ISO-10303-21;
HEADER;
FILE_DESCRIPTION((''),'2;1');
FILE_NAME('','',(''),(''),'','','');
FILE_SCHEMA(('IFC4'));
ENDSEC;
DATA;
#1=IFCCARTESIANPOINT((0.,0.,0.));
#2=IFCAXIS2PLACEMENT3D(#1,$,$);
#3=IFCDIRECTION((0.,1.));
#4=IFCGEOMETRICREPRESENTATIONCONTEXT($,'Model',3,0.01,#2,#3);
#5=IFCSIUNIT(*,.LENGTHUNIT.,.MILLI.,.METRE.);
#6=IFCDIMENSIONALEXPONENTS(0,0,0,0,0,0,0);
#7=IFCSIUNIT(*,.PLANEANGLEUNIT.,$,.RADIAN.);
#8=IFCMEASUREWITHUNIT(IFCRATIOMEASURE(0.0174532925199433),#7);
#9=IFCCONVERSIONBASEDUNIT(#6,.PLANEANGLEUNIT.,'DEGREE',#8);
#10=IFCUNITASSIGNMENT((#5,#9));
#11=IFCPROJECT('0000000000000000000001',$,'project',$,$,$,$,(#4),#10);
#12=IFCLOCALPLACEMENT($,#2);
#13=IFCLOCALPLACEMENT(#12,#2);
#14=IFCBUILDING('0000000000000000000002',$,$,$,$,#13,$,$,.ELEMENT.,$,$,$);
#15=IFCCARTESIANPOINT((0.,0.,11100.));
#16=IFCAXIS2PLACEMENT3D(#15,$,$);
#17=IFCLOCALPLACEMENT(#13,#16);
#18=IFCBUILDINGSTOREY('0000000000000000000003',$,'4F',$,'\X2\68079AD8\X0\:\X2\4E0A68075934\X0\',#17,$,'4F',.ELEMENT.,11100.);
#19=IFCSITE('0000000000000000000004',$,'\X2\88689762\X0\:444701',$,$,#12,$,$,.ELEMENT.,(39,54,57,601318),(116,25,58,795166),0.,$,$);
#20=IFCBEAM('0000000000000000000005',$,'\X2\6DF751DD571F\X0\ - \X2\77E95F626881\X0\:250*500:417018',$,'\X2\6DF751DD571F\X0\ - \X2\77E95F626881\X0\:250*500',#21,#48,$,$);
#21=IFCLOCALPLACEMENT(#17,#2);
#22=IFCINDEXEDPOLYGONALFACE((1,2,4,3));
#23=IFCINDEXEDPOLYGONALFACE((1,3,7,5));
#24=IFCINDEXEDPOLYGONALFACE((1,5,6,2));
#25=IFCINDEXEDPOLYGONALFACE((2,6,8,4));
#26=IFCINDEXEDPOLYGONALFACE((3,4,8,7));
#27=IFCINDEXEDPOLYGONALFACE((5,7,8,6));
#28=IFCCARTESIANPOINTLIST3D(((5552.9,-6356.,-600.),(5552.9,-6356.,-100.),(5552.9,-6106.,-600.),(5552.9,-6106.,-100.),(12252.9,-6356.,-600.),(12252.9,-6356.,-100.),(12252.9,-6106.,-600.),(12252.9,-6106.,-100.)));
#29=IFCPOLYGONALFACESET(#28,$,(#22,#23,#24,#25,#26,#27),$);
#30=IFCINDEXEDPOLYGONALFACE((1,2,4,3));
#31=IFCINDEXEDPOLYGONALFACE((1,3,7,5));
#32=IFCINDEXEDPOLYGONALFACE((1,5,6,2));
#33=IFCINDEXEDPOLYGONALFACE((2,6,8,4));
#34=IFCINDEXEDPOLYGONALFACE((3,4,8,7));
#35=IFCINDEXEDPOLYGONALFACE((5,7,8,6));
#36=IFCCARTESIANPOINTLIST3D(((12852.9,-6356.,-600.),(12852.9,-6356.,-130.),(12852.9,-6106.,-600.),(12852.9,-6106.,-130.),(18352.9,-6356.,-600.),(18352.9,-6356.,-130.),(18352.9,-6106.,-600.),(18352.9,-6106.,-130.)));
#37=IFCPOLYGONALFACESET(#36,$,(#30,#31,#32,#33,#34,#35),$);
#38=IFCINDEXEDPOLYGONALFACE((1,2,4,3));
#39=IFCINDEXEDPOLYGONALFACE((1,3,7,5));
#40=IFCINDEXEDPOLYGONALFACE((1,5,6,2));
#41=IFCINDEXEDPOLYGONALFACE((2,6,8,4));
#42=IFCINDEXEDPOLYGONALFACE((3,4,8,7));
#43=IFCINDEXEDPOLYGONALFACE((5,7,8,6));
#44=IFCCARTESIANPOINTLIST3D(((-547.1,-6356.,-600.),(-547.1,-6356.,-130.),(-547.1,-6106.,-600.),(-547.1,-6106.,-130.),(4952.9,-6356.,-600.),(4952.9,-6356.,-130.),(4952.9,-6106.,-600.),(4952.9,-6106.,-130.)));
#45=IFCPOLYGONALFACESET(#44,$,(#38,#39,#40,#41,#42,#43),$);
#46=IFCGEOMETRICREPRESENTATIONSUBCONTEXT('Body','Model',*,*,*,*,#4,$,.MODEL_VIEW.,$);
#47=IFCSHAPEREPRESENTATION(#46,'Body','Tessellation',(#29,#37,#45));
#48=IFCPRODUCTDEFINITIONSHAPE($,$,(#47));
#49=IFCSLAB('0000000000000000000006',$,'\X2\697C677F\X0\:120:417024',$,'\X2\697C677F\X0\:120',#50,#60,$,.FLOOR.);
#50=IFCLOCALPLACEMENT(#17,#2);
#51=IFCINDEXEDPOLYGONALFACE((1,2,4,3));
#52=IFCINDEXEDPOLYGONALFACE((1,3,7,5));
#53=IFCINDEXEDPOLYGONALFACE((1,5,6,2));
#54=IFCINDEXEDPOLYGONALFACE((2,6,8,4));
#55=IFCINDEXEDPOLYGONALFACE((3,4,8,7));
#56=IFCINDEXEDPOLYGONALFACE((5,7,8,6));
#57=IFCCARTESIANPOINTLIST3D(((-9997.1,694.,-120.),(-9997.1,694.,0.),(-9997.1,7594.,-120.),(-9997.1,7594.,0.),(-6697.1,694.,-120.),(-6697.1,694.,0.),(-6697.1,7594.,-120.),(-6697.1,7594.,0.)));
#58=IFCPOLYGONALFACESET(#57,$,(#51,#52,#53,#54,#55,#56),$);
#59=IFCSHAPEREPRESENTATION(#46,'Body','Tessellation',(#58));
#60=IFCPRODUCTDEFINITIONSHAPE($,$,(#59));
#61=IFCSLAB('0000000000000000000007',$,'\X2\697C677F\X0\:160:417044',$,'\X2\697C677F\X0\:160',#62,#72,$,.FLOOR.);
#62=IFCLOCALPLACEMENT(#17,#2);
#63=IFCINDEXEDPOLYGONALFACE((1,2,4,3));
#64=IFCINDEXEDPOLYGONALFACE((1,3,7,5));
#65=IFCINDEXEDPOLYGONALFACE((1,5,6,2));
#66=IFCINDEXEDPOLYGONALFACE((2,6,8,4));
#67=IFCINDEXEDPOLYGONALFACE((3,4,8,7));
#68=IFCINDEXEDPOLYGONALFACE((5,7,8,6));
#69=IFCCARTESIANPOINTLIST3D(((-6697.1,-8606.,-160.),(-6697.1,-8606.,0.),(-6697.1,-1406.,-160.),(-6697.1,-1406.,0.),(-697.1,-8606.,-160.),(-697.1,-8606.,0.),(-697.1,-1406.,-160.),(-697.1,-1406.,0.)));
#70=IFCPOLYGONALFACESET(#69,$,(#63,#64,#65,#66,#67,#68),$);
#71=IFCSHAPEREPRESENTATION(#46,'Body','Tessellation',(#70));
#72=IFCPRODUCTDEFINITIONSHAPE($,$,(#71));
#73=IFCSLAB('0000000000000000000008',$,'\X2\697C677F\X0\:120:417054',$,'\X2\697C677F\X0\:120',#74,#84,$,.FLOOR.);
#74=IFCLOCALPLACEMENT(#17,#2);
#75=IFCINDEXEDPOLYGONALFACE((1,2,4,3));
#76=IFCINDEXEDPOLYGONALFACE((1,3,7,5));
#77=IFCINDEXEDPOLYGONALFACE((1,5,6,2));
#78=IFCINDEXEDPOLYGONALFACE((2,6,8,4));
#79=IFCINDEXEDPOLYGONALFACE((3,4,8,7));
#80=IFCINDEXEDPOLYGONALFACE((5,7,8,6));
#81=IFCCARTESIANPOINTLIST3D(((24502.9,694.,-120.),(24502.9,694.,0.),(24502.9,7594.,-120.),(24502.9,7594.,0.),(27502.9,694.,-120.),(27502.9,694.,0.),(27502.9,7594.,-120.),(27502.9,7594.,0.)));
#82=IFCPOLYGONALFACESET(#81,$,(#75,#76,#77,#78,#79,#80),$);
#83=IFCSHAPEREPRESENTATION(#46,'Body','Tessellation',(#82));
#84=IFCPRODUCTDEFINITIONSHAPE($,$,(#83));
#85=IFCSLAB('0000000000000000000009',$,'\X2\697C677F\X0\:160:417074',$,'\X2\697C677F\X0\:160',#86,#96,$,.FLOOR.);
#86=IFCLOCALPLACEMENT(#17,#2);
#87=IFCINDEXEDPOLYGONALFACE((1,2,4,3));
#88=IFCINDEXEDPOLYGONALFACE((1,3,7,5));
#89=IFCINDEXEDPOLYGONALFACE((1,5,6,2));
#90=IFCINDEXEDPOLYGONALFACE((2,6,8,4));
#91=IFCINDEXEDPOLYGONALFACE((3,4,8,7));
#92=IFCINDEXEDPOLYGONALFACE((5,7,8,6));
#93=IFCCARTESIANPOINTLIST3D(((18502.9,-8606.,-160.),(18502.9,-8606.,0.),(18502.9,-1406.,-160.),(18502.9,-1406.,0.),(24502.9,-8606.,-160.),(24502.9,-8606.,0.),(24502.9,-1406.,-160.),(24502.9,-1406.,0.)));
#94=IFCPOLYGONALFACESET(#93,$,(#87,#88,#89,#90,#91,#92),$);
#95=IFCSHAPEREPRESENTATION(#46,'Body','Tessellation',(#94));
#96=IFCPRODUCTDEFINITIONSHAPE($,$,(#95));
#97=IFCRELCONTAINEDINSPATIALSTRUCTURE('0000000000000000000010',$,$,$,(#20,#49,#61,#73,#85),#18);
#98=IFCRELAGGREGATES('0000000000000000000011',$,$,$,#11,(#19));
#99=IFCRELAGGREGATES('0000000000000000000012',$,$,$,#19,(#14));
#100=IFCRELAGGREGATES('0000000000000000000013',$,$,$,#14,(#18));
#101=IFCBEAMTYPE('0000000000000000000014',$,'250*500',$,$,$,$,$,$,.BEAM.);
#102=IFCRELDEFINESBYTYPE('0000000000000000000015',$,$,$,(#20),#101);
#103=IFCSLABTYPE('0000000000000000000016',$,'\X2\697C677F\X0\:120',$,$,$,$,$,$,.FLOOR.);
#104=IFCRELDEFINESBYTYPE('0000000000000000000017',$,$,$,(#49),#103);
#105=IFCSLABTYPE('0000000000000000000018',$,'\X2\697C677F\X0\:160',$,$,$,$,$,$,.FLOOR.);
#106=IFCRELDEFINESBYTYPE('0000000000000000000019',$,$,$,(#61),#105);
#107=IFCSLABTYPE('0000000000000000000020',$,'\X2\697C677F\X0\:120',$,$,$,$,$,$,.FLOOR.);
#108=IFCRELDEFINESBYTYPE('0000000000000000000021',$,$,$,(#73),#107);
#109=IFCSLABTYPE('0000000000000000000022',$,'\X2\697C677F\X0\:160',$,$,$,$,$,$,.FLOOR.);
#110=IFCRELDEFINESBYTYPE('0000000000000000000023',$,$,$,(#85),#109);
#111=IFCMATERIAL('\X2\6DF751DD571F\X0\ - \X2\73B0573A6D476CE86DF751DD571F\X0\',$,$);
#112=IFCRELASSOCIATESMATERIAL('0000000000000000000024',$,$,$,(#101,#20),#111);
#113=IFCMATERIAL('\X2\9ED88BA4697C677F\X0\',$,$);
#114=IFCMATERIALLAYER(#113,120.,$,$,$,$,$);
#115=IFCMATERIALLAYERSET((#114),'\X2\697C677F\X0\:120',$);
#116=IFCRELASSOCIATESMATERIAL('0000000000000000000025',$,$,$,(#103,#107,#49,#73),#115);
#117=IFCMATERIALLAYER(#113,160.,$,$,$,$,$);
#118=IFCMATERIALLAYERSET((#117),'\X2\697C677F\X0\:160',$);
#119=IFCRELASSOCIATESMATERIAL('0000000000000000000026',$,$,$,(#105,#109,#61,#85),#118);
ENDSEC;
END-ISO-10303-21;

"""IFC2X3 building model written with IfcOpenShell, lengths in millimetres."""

from ifc_helpers import new_model, entity, si_unit, converted_unit, direction, frame, frame_2d, origin, place, context, subcontext, project, spatial, rectangle, extrude, source, transform, mapped, material, layer, layer_set, layer_usage, type_object, type_shapes, element, save


model = new_model("IFC2X3")

# Units and contexts
model_context = context("Model", 3, precision=0.01, world=origin(), true_north=direction((0.0, 1.0)))
body_context = subcontext(model_context, "Body", "Model", "MODEL_VIEW")
ifc_project = project(units=[si_unit("LENGTHUNIT", "METRE", prefix="MILLI"), converted_unit("PLANEANGLEUNIT", "DEGREE", entity("IfcRatioMeasure", 0.0174532925199433), si_unit("PLANEANGLEUNIT", "RADIAN"), dimensions=[0, 0, 0, 0, 0, 0, 0])], contexts=[model_context])

# Site, building, storey
site_placement = place(None, origin())
site = spatial("IfcSite", under=ifc_project, at=site_placement, Name="表面:444701", CompositionType="ELEMENT", RefLatitude=(39, 54, 57, 601318), RefLongitude=(116, 25, 58, 795166), RefElevation=0.0)
building_placement = place(site_placement, origin())
building = spatial("IfcBuilding", under=site, at=building_placement, CompositionType="ELEMENT")
storey_placement = place(building_placement, frame((0.0, 0.0, 11100.0)))
storey = spatial("IfcBuildingStorey", under=building, at=storey_placement, Name="4F", ObjectType="标高:上标头", LongName="4F", CompositionType="ELEMENT", Elevation=11100.0)

# Beam
ifc_material_1 = material(Name="混凝土 - 现场浇注混凝土")
beam_type_1 = type_object("IfcBeamType", Name="250*500", PredefinedType="BEAM", material=ifc_material_1)
shared_shape_1 = source(origin(), body_context, "Body", "SweptSolid", [
    extrude(rectangle(XDim=500.0, YDim=250.0, at=frame_2d((0.0, 0.0), x_axis=(1.0, 0.0))), frame((5552.9, -6231.0, 10750.0), z_axis=(1.0, 0.0, 0.0), x_axis=(0.0, 0.0, -1.0)), (0.0, 0.0, 1.0), 6700.0),
    extrude(rectangle(XDim=470.0, YDim=250.0, at=frame_2d((0.0, 0.0), x_axis=(1.0, 0.0))), frame((12852.9, -6231.0, 10735.0), z_axis=(1.0, 0.0, 0.0), x_axis=(0.0, 0.0, -1.0)), (0.0, 0.0, 1.0), 5500.0),
    extrude(rectangle(XDim=470.0, YDim=250.0, at=frame_2d((0.0, 0.0), x_axis=(1.0, 0.0))), frame((-547.1, -6231.0, 10735.0), z_axis=(1.0, 0.0, 0.0), x_axis=(0.0, 0.0, -1.0)), (0.0, 0.0, 1.0), 5500.0),
])
type_shapes(beam_type_1, [shared_shape_1])
beam_1_placement = place(storey_placement, frame((0.0, 0.0, -11100.0)))
element("IfcBeam", 1, at=beam_1_placement, inside=storey, type_object=beam_type_1, material=ifc_material_1, Name="混凝土 - 矩形梁:250*500:417018", ObjectType="混凝土 - 矩形梁:250*500", context=body_context, shape_type="MappedRepresentation", body=[
    mapped(shared_shape_1, transform((0.0, 0.0, 0.0), scale=1.0)),
])

# Slabs
ifc_material_2 = material(Name="默认楼板")
ifc_layer_1 = layer(ifc_material_2, 120.0)
ifc_layer_set_1 = layer_set([ifc_layer_1], Name="楼板:120")
ifc_layer_usage_1 = layer_usage(ifc_layer_set_1, "AXIS3", "POSITIVE", 0.0)
slab_type_1 = type_object("IfcSlabType", Name="楼板:120", PredefinedType="FLOOR", material=ifc_layer_set_1)
slab_1_placement = place(storey_placement, origin())
element("IfcSlab", 2, at=slab_1_placement, inside=storey, type_object=slab_type_1, material=ifc_layer_usage_1, Name="楼板:120:417024", ObjectType="楼板:120", PredefinedType="FLOOR", context=body_context, shape_type="SweptSolid", body=[
    extrude(rectangle(XDim=6900.0, YDim=3300.0, at=frame_2d((0.0, 0.0), x_axis=(1.0, 0.0))), frame((-8347.1, 4144.0, 0.0), z_axis=(0.0, 0.0, -1.0), x_axis=(0.0, 1.0, 0.0)), (0.0, 0.0, 1.0), 120.0),
])
ifc_layer_2 = layer(ifc_material_2, 160.0)
ifc_layer_set_2 = layer_set([ifc_layer_2], Name="楼板:160")
ifc_layer_usage_2 = layer_usage(ifc_layer_set_2, "AXIS3", "POSITIVE", 0.0)
slab_type_2 = type_object("IfcSlabType", Name="楼板:160", PredefinedType="FLOOR", material=ifc_layer_set_2)
slab_2_placement = place(storey_placement, origin())
element("IfcSlab", 3, at=slab_2_placement, inside=storey, type_object=slab_type_2, material=ifc_layer_usage_2, Name="楼板:160:417044", ObjectType="楼板:160", PredefinedType="FLOOR", context=body_context, shape_type="SweptSolid", body=[
    extrude(rectangle(XDim=7200.0, YDim=6000.0, at=frame_2d((0.0, 0.0), x_axis=(1.0, 0.0))), frame((-3697.1, -5006.0, 0.0), z_axis=(0.0, 0.0, -1.0), x_axis=(0.0, 1.0, 0.0)), (0.0, 0.0, 1.0), 160.0),
])
ifc_layer_usage_3 = layer_usage(ifc_layer_set_1, "AXIS3", "POSITIVE", 0.0)
slab_type_3 = type_object("IfcSlabType", Name="楼板:120", PredefinedType="FLOOR", material=ifc_layer_set_1)
slab_3_placement = place(storey_placement, origin())
element("IfcSlab", 4, at=slab_3_placement, inside=storey, type_object=slab_type_3, material=ifc_layer_usage_3, Name="楼板:120:417054", ObjectType="楼板:120", PredefinedType="FLOOR", context=body_context, shape_type="SweptSolid", body=[
    extrude(rectangle(XDim=6900.0, YDim=3000.0, at=frame_2d((0.0, 0.0), x_axis=(1.0, 0.0))), frame((26002.9, 4144.0, 0.0), z_axis=(0.0, 0.0, -1.0), x_axis=(0.0, 1.0, 0.0)), (0.0, 0.0, 1.0), 120.0),
])
ifc_layer_usage_4 = layer_usage(ifc_layer_set_2, "AXIS3", "POSITIVE", 0.0)
slab_type_4 = type_object("IfcSlabType", Name="楼板:160", PredefinedType="FLOOR", material=ifc_layer_set_2)
slab_4_placement = place(storey_placement, origin())
element("IfcSlab", 5, at=slab_4_placement, inside=storey, type_object=slab_type_4, material=ifc_layer_usage_4, Name="楼板:160:417074", ObjectType="楼板:160", PredefinedType="FLOOR", context=body_context, shape_type="SweptSolid", body=[
    extrude(rectangle(XDim=6000.0, YDim=7200.0, at=frame_2d((0.0, 0.0), x_axis=(1.0, 0.0))), frame((21502.9, -5006.0, 0.0), z_axis=(0.0, 0.0, -1.0), x_axis=(1.0, 0.0, 0.0)), (0.0, 0.0, 1.0), 160.0),
])

save(model, "model.ifc")
